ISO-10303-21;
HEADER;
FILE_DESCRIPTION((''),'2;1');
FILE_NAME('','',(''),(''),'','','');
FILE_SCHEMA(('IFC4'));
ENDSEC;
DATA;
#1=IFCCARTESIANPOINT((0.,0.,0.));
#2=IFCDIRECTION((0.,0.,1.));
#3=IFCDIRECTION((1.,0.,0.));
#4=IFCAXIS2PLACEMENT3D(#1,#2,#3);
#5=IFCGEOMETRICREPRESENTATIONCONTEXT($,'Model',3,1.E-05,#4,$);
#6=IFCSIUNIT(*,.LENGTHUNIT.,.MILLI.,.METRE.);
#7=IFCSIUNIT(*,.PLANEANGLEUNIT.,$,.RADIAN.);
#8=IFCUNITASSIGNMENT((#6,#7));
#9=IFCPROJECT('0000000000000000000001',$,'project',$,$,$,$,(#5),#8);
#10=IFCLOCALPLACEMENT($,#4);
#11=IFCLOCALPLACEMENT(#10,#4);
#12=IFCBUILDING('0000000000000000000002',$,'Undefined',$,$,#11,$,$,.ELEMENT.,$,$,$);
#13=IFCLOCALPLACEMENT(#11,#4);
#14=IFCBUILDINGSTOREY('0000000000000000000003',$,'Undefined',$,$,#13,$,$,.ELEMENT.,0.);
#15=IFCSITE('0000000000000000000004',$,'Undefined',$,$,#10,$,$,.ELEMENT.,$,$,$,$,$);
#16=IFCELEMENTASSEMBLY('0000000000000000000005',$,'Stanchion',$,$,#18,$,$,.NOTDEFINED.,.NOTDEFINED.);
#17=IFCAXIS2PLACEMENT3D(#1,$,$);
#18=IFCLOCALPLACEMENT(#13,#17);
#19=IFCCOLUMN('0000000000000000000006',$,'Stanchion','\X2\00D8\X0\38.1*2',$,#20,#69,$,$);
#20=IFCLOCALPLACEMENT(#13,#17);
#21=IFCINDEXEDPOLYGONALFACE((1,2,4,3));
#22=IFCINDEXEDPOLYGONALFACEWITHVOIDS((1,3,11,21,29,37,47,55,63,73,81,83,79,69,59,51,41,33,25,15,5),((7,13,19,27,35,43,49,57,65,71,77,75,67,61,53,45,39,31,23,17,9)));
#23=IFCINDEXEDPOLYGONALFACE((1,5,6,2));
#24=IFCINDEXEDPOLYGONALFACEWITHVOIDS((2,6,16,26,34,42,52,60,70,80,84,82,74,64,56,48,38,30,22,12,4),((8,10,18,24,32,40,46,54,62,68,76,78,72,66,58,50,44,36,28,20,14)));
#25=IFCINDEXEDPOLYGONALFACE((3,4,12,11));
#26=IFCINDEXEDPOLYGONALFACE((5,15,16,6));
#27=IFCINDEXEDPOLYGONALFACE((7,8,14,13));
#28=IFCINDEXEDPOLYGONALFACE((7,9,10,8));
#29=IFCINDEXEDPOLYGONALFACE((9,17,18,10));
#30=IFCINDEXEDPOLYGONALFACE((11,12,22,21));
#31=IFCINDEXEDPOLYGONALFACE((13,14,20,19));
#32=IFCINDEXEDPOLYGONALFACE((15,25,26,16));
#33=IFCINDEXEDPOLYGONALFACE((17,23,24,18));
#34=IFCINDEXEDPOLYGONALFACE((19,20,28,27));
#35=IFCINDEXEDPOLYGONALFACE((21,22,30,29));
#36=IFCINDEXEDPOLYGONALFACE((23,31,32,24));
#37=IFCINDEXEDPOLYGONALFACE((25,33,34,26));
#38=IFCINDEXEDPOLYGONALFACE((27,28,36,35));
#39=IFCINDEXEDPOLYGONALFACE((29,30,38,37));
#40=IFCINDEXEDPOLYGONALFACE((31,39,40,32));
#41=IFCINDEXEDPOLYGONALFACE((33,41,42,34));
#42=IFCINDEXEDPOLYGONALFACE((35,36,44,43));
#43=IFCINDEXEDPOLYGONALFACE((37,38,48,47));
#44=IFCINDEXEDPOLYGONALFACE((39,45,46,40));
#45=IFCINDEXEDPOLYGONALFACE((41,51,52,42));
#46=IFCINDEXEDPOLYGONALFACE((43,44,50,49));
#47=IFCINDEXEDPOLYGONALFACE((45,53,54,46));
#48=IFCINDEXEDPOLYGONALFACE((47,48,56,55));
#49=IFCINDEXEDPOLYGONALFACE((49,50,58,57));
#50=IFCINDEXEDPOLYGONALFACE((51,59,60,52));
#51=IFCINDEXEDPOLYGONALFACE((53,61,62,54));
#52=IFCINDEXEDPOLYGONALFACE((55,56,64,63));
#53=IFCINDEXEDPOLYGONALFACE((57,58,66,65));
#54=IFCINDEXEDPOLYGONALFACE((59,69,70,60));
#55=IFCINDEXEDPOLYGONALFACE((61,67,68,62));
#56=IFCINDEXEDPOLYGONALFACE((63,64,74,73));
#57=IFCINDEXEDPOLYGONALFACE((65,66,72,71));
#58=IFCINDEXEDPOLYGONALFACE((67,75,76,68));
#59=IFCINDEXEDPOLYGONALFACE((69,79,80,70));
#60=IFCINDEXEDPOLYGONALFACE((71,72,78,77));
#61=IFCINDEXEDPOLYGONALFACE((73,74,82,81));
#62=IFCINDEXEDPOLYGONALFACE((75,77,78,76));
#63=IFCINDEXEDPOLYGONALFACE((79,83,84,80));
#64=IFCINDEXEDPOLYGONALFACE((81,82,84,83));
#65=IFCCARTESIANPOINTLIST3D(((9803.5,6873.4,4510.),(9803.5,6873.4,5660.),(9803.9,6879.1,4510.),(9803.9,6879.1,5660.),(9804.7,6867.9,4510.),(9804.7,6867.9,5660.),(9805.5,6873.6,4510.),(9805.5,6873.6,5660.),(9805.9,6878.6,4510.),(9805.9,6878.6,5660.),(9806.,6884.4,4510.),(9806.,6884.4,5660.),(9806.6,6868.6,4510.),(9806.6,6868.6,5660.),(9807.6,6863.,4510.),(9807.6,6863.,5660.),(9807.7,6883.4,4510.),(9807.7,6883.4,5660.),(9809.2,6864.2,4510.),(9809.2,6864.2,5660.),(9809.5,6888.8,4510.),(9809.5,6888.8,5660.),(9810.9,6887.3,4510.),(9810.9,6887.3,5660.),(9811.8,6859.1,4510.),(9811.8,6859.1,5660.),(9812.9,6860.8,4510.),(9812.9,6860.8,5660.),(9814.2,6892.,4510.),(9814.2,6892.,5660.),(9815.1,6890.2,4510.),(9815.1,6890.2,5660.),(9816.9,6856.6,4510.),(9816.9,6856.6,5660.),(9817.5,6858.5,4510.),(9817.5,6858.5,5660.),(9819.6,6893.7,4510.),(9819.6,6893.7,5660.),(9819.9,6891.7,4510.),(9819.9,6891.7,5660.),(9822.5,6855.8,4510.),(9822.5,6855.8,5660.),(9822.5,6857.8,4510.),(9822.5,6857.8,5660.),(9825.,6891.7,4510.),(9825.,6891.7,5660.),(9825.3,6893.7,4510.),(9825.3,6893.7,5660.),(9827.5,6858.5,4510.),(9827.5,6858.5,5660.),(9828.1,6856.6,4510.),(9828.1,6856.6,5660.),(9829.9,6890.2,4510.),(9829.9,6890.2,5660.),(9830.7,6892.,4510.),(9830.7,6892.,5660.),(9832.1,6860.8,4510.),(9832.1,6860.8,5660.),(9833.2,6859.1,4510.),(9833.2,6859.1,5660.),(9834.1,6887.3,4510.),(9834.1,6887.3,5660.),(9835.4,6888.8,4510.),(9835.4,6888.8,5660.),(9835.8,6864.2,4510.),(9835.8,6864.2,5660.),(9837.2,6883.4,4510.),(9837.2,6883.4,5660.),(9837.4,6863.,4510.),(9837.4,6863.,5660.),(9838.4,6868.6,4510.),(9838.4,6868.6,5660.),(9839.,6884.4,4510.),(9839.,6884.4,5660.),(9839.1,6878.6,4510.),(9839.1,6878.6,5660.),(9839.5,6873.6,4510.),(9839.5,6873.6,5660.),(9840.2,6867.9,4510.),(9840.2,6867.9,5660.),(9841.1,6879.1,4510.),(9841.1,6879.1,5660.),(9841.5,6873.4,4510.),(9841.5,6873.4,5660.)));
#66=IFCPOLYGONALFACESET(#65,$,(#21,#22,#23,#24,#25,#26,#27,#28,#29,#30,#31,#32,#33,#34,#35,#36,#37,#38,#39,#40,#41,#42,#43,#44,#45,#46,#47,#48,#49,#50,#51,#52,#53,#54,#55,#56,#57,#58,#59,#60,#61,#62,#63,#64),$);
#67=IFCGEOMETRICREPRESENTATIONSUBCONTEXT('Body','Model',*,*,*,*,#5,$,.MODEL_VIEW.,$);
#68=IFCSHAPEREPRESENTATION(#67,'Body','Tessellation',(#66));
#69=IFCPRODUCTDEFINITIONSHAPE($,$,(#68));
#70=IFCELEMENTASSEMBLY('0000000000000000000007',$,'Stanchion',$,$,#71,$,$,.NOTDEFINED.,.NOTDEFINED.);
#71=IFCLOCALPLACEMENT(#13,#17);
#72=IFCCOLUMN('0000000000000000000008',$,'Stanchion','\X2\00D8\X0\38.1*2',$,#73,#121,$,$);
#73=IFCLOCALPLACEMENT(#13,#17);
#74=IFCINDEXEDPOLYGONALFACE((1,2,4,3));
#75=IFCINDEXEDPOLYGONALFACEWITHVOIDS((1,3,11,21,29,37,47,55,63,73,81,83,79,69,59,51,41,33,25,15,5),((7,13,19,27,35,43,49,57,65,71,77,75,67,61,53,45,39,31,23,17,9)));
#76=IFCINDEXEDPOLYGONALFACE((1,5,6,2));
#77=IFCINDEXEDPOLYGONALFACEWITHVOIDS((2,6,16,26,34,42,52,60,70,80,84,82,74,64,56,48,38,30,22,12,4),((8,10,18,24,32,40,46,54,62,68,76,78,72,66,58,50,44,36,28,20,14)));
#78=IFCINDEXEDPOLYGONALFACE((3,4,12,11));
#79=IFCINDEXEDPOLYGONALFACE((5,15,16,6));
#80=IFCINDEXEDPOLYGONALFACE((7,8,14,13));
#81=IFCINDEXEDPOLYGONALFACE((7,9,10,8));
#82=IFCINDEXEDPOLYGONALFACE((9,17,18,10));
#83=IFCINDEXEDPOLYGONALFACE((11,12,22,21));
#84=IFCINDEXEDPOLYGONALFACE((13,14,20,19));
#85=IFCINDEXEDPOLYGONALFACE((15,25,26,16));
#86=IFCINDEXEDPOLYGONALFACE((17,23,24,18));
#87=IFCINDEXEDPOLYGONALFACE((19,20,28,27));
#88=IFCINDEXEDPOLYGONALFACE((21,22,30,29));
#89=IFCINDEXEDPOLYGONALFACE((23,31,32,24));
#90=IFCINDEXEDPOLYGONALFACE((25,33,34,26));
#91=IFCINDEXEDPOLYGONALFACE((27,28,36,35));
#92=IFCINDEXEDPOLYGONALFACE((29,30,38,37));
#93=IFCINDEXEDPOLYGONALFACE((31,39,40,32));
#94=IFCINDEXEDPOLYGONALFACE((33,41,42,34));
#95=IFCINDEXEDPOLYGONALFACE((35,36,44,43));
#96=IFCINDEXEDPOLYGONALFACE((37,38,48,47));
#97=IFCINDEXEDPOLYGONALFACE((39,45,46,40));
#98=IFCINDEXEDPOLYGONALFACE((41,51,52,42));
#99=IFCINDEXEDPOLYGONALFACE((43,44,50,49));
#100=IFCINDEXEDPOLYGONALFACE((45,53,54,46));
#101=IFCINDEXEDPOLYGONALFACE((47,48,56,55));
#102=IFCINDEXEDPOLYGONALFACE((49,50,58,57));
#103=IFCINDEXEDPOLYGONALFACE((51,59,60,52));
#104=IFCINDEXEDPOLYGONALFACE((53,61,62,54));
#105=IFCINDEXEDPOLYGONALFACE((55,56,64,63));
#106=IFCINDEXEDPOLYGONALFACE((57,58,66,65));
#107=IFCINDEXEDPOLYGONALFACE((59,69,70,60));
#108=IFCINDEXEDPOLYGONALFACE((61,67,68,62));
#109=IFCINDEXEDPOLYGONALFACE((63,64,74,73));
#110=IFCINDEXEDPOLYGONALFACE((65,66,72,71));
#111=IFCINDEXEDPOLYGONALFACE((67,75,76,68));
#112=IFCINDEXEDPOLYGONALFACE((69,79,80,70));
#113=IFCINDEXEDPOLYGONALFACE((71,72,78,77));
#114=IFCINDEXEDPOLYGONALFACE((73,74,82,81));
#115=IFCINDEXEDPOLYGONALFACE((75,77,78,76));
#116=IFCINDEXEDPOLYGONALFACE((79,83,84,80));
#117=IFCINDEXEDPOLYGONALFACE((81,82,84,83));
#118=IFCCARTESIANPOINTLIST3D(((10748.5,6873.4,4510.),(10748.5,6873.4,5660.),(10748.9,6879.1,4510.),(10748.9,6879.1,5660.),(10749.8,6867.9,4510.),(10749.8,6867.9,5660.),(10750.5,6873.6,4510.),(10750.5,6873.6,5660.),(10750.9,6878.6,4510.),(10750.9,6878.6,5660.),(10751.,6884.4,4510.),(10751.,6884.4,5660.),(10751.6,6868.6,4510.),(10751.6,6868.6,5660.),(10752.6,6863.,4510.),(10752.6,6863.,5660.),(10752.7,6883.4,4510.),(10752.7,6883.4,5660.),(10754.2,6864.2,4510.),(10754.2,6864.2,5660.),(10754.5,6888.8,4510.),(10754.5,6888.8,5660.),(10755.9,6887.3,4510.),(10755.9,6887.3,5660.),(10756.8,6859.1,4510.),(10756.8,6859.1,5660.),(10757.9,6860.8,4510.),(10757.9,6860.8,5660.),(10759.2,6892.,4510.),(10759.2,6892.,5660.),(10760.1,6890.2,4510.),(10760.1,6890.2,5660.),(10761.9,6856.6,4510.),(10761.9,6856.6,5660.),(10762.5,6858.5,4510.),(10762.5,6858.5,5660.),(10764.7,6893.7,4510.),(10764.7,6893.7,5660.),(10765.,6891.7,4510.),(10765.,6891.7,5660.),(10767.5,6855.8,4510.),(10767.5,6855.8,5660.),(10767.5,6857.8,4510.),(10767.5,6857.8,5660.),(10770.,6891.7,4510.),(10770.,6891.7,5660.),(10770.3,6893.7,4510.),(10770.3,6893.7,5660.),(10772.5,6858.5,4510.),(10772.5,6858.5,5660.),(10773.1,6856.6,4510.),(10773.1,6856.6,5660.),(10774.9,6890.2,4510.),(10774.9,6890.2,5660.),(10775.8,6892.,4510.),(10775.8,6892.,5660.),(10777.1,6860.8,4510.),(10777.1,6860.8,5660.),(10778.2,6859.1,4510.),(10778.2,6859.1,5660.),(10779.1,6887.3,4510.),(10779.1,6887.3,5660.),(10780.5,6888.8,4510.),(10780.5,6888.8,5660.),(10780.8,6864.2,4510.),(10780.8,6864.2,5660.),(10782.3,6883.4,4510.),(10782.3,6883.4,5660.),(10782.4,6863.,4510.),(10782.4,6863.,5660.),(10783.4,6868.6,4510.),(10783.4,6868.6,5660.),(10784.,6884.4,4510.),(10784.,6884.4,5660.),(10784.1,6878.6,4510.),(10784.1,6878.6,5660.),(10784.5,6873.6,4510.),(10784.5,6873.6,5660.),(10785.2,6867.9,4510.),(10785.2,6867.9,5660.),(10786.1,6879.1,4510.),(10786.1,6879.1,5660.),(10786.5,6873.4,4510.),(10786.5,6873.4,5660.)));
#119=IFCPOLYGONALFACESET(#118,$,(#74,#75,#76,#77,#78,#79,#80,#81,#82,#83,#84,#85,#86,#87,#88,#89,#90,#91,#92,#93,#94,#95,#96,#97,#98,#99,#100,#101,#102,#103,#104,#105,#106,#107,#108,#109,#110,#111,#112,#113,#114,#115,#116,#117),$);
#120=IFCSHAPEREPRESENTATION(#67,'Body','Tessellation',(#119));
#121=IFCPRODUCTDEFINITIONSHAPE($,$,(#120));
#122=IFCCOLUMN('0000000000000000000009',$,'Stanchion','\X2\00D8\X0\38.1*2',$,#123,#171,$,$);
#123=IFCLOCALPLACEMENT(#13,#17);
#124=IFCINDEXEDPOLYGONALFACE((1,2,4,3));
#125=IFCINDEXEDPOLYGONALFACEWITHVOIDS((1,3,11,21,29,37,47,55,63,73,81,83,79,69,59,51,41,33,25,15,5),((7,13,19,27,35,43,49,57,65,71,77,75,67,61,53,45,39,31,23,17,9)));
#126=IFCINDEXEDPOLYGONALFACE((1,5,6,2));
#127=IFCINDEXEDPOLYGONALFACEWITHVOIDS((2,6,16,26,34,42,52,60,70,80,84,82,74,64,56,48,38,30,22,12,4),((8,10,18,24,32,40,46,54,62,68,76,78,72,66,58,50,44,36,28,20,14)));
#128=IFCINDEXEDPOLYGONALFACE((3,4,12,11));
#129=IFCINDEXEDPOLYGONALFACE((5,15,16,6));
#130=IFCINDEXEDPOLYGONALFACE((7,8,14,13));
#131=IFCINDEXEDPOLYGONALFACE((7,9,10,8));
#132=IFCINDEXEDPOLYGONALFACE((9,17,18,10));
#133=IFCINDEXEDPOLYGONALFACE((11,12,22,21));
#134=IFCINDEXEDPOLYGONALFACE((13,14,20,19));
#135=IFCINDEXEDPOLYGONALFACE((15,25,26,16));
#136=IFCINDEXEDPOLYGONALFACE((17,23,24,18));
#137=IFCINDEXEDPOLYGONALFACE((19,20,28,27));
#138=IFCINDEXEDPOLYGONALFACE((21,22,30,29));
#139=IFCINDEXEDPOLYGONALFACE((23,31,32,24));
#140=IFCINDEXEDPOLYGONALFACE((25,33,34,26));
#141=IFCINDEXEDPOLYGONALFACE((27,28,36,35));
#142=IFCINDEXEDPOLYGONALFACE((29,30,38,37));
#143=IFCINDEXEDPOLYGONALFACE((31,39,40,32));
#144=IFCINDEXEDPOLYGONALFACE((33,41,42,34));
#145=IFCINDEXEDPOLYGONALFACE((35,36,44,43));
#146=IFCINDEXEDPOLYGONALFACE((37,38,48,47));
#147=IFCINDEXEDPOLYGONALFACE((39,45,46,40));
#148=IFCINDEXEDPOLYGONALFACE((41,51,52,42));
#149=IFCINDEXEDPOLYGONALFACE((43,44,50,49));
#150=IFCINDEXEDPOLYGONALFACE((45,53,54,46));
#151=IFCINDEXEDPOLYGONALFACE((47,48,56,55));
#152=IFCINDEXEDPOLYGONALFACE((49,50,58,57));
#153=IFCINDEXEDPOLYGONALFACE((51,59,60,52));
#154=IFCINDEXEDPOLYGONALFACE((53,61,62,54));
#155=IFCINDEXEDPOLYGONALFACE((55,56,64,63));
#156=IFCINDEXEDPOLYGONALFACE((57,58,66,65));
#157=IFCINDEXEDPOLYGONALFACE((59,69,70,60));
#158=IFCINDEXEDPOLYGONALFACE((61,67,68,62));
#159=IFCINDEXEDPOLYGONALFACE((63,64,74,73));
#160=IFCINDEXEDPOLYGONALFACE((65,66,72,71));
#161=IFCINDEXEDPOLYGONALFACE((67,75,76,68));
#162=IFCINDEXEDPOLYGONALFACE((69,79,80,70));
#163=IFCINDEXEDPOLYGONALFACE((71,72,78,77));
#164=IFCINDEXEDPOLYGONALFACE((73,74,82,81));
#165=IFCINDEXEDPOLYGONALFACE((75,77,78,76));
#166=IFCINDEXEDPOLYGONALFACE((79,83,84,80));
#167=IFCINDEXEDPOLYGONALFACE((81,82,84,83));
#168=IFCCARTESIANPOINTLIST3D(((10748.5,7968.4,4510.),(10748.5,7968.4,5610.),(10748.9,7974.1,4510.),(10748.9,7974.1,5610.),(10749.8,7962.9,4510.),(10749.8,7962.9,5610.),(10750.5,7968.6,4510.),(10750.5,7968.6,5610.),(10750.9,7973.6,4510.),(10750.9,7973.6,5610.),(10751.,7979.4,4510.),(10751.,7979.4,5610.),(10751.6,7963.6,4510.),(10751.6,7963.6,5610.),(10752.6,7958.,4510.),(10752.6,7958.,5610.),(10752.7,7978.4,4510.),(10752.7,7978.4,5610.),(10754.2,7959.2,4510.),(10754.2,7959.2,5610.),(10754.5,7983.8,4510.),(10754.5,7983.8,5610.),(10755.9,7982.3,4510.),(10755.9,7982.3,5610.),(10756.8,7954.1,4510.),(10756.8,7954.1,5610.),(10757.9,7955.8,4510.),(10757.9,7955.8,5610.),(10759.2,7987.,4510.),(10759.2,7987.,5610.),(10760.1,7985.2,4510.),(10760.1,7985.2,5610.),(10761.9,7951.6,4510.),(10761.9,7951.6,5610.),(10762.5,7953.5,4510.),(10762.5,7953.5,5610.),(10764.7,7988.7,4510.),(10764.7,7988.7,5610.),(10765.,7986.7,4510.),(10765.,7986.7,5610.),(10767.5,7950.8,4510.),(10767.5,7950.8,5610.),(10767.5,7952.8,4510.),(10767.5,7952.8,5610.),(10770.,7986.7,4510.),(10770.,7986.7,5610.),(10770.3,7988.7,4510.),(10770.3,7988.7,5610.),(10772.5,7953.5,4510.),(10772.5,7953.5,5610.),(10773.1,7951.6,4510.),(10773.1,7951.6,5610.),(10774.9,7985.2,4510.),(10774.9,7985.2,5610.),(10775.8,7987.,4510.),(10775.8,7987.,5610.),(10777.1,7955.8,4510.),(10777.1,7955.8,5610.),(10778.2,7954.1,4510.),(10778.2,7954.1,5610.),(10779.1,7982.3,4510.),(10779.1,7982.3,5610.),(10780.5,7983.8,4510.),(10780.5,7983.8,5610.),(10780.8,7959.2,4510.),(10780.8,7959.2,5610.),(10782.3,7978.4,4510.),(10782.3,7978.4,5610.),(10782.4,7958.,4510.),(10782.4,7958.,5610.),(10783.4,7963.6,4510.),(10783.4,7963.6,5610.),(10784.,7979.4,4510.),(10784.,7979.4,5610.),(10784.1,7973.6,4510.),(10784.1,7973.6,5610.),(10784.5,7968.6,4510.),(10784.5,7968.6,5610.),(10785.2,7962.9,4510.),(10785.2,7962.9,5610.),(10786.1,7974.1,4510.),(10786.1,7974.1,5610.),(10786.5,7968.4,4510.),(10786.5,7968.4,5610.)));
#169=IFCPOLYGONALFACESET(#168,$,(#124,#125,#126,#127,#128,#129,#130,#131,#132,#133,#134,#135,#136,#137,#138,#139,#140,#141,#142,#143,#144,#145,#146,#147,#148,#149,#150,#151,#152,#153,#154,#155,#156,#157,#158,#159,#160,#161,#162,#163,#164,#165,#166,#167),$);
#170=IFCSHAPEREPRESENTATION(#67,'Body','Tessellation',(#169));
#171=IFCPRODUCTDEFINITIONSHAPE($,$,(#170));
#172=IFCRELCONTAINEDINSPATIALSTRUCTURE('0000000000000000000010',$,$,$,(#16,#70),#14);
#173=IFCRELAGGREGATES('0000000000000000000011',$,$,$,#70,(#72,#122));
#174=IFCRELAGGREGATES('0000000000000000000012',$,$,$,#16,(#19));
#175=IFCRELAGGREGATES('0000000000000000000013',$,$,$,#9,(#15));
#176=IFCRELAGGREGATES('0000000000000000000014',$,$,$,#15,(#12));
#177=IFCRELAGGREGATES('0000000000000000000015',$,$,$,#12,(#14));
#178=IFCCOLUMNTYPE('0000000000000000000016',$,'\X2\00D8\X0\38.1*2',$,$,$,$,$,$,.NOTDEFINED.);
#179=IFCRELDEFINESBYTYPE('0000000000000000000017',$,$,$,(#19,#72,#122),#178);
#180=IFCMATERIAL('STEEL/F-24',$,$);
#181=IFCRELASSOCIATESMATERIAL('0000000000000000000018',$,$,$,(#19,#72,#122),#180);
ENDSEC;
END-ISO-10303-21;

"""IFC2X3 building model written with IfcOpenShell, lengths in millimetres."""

from ifc_helpers import new_model, si_unit, frame, origin_with_axes, origin_2d_with_axis, place, context, subcontext, project, spatial, hollow_circle, extrude, material, type_object, element, aggregate, save


model = new_model("IFC2X3")

# Units and contexts
model_context = context("Model", 3, precision=1e-05, world=origin_with_axes())
body_context = subcontext(model_context, "Body", "Model", "MODEL_VIEW")
ifc_project = project(units=[si_unit("LENGTHUNIT", "METRE", prefix="MILLI"), si_unit("PLANEANGLEUNIT", "RADIAN")], contexts=[model_context])

# Site, building, storey
site_placement = place(None, origin_with_axes())
site = spatial("IfcSite", under=ifc_project, at=site_placement, Name="Undefined", CompositionType="ELEMENT")
building_placement = place(site_placement, origin_with_axes())
building = spatial("IfcBuilding", under=site, at=building_placement, Name="Undefined", CompositionType="ELEMENT")
storey_placement = place(building_placement, origin_with_axes())
storey = spatial("IfcBuildingStorey", under=building, at=storey_placement, Name="Undefined", CompositionType="ELEMENT", Elevation=0.0)

# Element assemblies, columns
ifc_material_1 = material(Name="STEEL/F-24")
column_type = type_object("IfcColumnType", Name="Ø38.1*2", PredefinedType="NOTDEFINED")
assembly_1_placement = place(storey_placement, origin_with_axes())
assembly_1 = element("IfcElementAssembly", 1, at=assembly_1_placement, inside=storey, Name="Stanchion", AssemblyPlace="NOTDEFINED", PredefinedType="NOTDEFINED")
column_1_placement = place(assembly_1_placement, frame((9822.5, 6874.8, 4510.0), z_axis=(0.0, 0.0, 1.0), x_axis=(-1.0, 0.0, 0.0)))
column_1 = element("IfcColumn", 2, at=column_1_placement, type_object=column_type, material=ifc_material_1, Name="Stanchion", Description="Ø38.1*2", context=body_context, shape_type="SweptSolid", body=[
    extrude(hollow_circle(Radius=19.1, WallThickness=2.0, at=origin_2d_with_axis()), frame((0.0, 0.0, 1150.0), z_axis=(0.0, 0.0, -1.0), x_axis=(0.0, 1.0, 0.0)), (0.0, 0.0, 1.0), 1150.0),
])
assembly_2_placement = place(storey_placement, origin_with_axes())
assembly_2 = element("IfcElementAssembly", 3, at=assembly_2_placement, inside=storey, Name="Stanchion", AssemblyPlace="NOTDEFINED", PredefinedType="NOTDEFINED")
column_2_placement = place(assembly_2_placement, frame((10767.5, 6874.8, 4510.0), z_axis=(0.0, 0.0, 1.0), x_axis=(-1.0, 0.0, 0.0)))
column_2 = element("IfcColumn", 4, at=column_2_placement, type_object=column_type, material=ifc_material_1, Name="Stanchion", Description="Ø38.1*2", context=body_context, shape_type="SweptSolid", body=[
    extrude(hollow_circle(Radius=19.1, WallThickness=2.0, at=origin_2d_with_axis()), frame((0.0, 0.0, 1150.0), z_axis=(0.0, 0.0, -1.0), x_axis=(0.0, 1.0, 0.0)), (0.0, 0.0, 1.0), 1150.0),
])
column_3_placement = place(assembly_2_placement, frame((10767.5, 7969.8, 4510.0), z_axis=(0.0, 0.0, 1.0), x_axis=(-1.0, 0.0, 0.0)))
column_3 = element("IfcColumn", 5, at=column_3_placement, type_object=column_type, material=ifc_material_1, Name="Stanchion", Description="Ø38.1*2", context=body_context, shape_type="SweptSolid", body=[
    extrude(hollow_circle(Radius=19.1, WallThickness=2.0, at=origin_2d_with_axis()), frame((0.0, 0.0, 1100.0), z_axis=(0.0, 0.0, -1.0), x_axis=(0.0, 1.0, 0.0)), (0.0, 0.0, 1.0), 1100.0),
])

aggregate(assembly_2, [column_2, column_3])
aggregate(assembly_1, [column_1])

save(model, "model.ifc")
